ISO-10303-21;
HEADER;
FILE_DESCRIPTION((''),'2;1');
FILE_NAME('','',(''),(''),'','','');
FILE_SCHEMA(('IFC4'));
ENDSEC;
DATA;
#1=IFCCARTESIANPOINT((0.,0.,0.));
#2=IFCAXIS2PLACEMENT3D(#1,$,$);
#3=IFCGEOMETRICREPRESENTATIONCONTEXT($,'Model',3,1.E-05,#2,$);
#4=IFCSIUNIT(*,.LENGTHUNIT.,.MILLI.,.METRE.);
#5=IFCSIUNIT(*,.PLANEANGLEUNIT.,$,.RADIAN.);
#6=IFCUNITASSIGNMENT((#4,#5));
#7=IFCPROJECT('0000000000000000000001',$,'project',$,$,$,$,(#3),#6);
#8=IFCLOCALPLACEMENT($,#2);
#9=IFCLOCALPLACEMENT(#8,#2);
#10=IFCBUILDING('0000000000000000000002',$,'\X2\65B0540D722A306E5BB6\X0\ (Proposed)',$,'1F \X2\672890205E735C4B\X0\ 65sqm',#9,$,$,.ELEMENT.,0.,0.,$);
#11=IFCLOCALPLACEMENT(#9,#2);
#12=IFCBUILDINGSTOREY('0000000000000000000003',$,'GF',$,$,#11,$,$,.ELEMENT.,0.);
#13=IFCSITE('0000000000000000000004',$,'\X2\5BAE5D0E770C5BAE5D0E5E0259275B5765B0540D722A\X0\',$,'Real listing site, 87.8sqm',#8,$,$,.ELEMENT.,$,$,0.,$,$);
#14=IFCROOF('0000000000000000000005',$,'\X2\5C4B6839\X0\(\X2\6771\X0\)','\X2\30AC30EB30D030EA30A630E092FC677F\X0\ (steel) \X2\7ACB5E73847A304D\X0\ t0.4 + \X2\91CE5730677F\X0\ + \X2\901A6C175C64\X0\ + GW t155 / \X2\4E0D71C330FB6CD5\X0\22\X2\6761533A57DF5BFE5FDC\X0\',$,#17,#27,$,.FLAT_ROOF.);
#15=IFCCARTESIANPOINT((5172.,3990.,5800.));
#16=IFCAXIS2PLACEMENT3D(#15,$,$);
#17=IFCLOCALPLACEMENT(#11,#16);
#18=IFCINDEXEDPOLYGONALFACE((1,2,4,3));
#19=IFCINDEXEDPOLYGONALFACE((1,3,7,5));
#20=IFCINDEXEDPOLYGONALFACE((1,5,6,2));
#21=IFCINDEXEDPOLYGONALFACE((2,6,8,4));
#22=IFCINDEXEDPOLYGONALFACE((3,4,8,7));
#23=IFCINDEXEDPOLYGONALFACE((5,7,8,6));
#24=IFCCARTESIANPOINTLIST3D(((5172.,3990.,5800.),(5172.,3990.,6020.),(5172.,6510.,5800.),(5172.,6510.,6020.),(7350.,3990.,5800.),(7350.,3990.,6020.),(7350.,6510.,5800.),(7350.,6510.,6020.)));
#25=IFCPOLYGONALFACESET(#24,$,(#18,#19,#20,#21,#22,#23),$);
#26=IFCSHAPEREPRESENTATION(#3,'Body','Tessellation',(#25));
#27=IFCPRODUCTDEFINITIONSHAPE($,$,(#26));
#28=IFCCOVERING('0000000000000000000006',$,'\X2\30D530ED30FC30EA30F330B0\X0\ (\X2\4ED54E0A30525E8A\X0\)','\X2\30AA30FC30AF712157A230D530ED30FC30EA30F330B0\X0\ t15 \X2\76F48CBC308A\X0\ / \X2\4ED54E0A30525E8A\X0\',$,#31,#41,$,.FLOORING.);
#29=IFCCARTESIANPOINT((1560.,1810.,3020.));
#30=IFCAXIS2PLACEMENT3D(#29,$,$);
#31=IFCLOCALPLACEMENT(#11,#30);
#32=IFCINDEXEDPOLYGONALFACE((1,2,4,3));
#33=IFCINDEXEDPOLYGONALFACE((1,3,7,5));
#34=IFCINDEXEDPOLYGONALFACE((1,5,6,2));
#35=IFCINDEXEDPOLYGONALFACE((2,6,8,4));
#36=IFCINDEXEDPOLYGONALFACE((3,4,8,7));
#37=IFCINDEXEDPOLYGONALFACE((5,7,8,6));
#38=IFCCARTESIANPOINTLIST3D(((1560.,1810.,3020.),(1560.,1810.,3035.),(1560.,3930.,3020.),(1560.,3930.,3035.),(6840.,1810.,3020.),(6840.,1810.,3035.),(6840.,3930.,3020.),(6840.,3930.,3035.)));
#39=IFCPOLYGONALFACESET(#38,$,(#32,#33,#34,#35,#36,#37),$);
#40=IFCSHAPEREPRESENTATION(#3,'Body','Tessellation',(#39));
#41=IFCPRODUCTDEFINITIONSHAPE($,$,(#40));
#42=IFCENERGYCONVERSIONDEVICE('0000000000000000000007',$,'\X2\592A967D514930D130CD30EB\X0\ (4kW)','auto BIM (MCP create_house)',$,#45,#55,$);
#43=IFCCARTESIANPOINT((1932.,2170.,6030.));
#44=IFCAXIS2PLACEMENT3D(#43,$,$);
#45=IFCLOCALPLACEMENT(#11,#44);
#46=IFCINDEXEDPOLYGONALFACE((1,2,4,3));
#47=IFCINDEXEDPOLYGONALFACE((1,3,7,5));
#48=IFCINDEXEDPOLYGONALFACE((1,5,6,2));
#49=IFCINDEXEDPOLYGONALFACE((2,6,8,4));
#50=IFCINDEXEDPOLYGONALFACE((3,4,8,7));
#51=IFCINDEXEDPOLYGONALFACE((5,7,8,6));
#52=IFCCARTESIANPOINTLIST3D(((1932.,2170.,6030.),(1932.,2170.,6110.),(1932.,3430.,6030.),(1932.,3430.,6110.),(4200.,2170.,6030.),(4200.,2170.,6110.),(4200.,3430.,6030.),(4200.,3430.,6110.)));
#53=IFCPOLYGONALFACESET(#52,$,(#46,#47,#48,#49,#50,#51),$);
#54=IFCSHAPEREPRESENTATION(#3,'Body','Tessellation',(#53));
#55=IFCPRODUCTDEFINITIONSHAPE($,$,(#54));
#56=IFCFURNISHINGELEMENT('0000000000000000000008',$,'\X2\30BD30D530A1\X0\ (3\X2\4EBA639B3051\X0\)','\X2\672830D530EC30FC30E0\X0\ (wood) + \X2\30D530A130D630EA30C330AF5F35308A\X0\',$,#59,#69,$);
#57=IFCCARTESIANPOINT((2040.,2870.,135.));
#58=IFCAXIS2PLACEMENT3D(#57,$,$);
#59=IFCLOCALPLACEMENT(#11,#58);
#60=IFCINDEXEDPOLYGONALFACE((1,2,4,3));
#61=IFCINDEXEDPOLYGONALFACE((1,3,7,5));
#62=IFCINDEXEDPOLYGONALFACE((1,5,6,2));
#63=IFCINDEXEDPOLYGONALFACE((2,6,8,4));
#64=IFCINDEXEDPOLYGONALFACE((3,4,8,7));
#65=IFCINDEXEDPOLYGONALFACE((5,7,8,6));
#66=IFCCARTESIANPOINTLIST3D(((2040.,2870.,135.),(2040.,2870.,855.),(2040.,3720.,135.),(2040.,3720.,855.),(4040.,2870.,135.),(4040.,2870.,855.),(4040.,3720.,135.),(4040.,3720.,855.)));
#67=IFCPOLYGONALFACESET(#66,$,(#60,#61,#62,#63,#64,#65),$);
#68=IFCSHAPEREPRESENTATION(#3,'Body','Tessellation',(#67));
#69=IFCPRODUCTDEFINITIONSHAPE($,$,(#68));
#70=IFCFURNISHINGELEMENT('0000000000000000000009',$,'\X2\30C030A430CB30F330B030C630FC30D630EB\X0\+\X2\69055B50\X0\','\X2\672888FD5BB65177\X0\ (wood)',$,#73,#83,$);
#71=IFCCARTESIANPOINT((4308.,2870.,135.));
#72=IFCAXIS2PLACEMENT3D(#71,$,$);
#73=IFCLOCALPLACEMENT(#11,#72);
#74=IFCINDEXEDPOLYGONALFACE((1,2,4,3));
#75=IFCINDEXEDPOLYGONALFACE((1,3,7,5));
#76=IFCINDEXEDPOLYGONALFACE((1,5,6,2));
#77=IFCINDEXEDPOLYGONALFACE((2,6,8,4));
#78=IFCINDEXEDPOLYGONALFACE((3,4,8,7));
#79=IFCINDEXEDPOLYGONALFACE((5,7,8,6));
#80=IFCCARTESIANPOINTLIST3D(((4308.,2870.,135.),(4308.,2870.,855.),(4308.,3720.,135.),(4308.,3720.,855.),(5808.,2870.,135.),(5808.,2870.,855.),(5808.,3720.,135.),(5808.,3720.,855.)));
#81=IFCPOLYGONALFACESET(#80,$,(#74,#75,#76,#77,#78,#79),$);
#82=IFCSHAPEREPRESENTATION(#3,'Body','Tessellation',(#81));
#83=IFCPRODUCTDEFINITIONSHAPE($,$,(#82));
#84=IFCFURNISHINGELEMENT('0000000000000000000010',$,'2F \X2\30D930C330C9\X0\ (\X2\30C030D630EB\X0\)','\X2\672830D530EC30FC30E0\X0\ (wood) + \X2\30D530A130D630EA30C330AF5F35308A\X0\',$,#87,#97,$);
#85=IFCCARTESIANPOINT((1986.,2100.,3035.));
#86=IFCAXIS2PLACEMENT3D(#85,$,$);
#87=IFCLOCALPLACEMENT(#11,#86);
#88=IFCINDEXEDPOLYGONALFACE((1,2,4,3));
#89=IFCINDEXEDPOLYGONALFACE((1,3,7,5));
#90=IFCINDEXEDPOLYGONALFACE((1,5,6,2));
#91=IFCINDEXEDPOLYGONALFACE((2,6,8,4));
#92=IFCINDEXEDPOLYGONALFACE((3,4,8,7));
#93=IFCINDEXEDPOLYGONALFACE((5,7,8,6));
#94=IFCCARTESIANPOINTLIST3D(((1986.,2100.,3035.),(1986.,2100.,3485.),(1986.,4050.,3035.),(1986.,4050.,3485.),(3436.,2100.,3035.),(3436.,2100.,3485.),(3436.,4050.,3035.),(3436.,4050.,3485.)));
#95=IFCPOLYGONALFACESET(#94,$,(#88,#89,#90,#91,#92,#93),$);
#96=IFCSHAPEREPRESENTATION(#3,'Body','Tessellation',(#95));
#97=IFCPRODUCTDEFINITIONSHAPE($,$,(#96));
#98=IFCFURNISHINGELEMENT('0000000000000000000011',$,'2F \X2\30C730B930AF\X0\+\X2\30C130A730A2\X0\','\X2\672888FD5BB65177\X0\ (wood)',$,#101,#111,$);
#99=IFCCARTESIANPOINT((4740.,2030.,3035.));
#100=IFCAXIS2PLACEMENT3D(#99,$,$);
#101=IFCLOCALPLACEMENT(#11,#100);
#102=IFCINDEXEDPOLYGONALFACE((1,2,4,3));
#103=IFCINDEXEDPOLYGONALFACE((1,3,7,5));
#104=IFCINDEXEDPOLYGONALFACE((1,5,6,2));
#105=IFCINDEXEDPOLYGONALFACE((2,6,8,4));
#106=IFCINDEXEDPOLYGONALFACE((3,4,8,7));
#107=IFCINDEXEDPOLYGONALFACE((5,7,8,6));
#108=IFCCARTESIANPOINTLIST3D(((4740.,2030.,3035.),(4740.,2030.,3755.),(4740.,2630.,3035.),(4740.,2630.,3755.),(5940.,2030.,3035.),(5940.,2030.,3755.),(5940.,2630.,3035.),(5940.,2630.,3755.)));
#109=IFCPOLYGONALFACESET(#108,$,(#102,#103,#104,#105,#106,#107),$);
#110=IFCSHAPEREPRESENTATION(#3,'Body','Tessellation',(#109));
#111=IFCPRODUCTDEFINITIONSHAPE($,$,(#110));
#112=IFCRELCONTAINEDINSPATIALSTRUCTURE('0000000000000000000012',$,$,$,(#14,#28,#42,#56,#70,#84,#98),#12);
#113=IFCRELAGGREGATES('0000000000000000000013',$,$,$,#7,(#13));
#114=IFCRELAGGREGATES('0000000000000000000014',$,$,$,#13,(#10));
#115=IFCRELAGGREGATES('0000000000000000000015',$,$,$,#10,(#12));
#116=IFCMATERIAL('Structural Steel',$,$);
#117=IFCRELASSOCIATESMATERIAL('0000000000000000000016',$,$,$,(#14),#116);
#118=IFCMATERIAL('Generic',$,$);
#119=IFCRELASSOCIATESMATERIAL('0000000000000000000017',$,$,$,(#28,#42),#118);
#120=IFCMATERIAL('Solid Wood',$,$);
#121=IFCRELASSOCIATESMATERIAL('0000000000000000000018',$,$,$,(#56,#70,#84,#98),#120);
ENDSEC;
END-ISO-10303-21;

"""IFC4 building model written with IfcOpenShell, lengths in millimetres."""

from ifc_helpers import new_model, si_unit, frame, frame_2d, origin, place, context, project, spatial, rectangle, extrude, material, element, save


model = new_model("IFC4")

# Units and contexts
model_context = context("Model", 3, precision=1e-05, world=origin())
ifc_project = project(units=[si_unit("LENGTHUNIT", "METRE", prefix="MILLI"), si_unit("PLANEANGLEUNIT", "RADIAN")], contexts=[model_context])

# Site, building, storey
site_placement = place(None, origin())
site = spatial("IfcSite", under=ifc_project, at=site_placement, Name="宮崎県宮崎市大字新名爪", ObjectType="Real listing site, 87.8sqm", CompositionType="ELEMENT", RefElevation=0.0)
building_placement = place(site_placement, origin())
building = spatial("IfcBuilding", under=site, at=building_placement, Name="新名爪の家 (Proposed)", ObjectType="1F 木造平屋 65sqm", CompositionType="ELEMENT", ElevationOfRefHeight=0.0, ElevationOfTerrain=0.0)
storey_placement = place(building_placement, origin())
storey = spatial("IfcBuildingStorey", under=building, at=storey_placement, Name="GF", CompositionType="ELEMENT", Elevation=0.0)

# Shared definitions
ifc_material_1 = material(Name="Solid Wood")

# Roof
ifc_material_2 = material(Name="Structural Steel")
roof_1_placement = place(storey_placement, frame((5172.0, 3990.0, 5800.0)))
element("IfcRoof", 1, at=roof_1_placement, inside=storey, material=ifc_material_2, Name="屋根(東)", Description="ガルバリウム鋼板 (steel) 立平葺き t0.4 + 野地板 + 通気層 + GW t155 / 不燃・法22条区域対応", PredefinedType="FLAT_ROOF", context=model_context, shape_type="SweptSolid", body=[
    extrude(rectangle(XDim=2178.0, YDim=2520.0, at=frame_2d((1089.0, 1260.0))), frame((5172.0, 3990.0, 5800.0)), (0.0, 0.0, 1.0), 220.0),
])

# Covering
ifc_material_3 = material(Name="Generic")
covering_placement = place(storey_placement, frame((1560.0, 1810.0, 3020.0)))
element("IfcCovering", 2, at=covering_placement, inside=storey, material=ifc_material_3, Name="フローリング (仕上げ床)", Description="オーク無垢フローリング t15 直貼り / 仕上げ床", PredefinedType="FLOORING", context=model_context, shape_type="SweptSolid", body=[
    extrude(rectangle(XDim=5280.0, YDim=2120.0, at=frame_2d((2640.0, 1060.0))), frame((1560.0, 1810.0, 3020.0)), (0.0, 0.0, 1.0), 15.0),
])

# Energy conversion device
energy_conversion_device_placement = place(storey_placement, frame((1932.0, 2170.0, 6030.0)))
element("IfcEnergyConversionDevice", 3, at=energy_conversion_device_placement, inside=storey, material=ifc_material_3, Name="太陽光パネル (4kW)", Description="auto BIM (MCP create_house)", context=model_context, shape_type="SweptSolid", body=[
    extrude(rectangle(XDim=2268.0, YDim=1260.0, at=frame_2d((1134.0, 630.0))), frame((1932.0, 2170.0, 6030.0)), (0.0, 0.0, 1.0), 80.0),
])

# Furnishing elements
furnishing_1_placement = place(storey_placement, frame((2040.0, 2870.0, 135.0)))
element("IfcFurnishingElement", 4, at=furnishing_1_placement, inside=storey, material=ifc_material_1, Name="ソファ (3人掛け)", Description="木フレーム (wood) + ファブリック張り", context=model_context, shape_type="SweptSolid", body=[
    extrude(rectangle(XDim=2000.0, YDim=850.0, at=frame_2d((1000.0, 425.0))), frame((2040.0, 2870.0, 135.0)), (0.0, 0.0, 1.0), 720.0),
])
furnishing_2_placement = place(storey_placement, frame((4308.0, 2870.0, 135.0)))
element("IfcFurnishingElement", 5, at=furnishing_2_placement, inside=storey, material=ifc_material_1, Name="ダイニングテーブル+椅子", Description="木製家具 (wood)", context=model_context, shape_type="SweptSolid", body=[
    extrude(rectangle(XDim=1500.0, YDim=850.0, at=frame_2d((750.0, 425.0))), frame((4308.0, 2870.0, 135.0)), (0.0, 0.0, 1.0), 720.0),
])
furnishing_3_placement = place(storey_placement, frame((1986.0, 2100.0, 3035.0)))
element("IfcFurnishingElement", 6, at=furnishing_3_placement, inside=storey, material=ifc_material_1, Name="2F ベッド (ダブル)", Description="木フレーム (wood) + ファブリック張り", context=model_context, shape_type="SweptSolid", body=[
    extrude(rectangle(XDim=1450.0, YDim=1950.0, at=frame_2d((725.0, 975.0))), frame((1986.0, 2100.0, 3035.0)), (0.0, 0.0, 1.0), 450.0),
])
furnishing_4_placement = place(storey_placement, frame((4740.0, 2030.0, 3035.0)))
element("IfcFurnishingElement", 7, at=furnishing_4_placement, inside=storey, material=ifc_material_1, Name="2F デスク+チェア", Description="木製家具 (wood)", context=model_context, shape_type="SweptSolid", body=[
    extrude(rectangle(XDim=1200.0, YDim=600.0, at=frame_2d((600.0, 300.0))), frame((4740.0, 2030.0, 3035.0)), (0.0, 0.0, 1.0), 720.0),
])

save(model, "model.ifc")
